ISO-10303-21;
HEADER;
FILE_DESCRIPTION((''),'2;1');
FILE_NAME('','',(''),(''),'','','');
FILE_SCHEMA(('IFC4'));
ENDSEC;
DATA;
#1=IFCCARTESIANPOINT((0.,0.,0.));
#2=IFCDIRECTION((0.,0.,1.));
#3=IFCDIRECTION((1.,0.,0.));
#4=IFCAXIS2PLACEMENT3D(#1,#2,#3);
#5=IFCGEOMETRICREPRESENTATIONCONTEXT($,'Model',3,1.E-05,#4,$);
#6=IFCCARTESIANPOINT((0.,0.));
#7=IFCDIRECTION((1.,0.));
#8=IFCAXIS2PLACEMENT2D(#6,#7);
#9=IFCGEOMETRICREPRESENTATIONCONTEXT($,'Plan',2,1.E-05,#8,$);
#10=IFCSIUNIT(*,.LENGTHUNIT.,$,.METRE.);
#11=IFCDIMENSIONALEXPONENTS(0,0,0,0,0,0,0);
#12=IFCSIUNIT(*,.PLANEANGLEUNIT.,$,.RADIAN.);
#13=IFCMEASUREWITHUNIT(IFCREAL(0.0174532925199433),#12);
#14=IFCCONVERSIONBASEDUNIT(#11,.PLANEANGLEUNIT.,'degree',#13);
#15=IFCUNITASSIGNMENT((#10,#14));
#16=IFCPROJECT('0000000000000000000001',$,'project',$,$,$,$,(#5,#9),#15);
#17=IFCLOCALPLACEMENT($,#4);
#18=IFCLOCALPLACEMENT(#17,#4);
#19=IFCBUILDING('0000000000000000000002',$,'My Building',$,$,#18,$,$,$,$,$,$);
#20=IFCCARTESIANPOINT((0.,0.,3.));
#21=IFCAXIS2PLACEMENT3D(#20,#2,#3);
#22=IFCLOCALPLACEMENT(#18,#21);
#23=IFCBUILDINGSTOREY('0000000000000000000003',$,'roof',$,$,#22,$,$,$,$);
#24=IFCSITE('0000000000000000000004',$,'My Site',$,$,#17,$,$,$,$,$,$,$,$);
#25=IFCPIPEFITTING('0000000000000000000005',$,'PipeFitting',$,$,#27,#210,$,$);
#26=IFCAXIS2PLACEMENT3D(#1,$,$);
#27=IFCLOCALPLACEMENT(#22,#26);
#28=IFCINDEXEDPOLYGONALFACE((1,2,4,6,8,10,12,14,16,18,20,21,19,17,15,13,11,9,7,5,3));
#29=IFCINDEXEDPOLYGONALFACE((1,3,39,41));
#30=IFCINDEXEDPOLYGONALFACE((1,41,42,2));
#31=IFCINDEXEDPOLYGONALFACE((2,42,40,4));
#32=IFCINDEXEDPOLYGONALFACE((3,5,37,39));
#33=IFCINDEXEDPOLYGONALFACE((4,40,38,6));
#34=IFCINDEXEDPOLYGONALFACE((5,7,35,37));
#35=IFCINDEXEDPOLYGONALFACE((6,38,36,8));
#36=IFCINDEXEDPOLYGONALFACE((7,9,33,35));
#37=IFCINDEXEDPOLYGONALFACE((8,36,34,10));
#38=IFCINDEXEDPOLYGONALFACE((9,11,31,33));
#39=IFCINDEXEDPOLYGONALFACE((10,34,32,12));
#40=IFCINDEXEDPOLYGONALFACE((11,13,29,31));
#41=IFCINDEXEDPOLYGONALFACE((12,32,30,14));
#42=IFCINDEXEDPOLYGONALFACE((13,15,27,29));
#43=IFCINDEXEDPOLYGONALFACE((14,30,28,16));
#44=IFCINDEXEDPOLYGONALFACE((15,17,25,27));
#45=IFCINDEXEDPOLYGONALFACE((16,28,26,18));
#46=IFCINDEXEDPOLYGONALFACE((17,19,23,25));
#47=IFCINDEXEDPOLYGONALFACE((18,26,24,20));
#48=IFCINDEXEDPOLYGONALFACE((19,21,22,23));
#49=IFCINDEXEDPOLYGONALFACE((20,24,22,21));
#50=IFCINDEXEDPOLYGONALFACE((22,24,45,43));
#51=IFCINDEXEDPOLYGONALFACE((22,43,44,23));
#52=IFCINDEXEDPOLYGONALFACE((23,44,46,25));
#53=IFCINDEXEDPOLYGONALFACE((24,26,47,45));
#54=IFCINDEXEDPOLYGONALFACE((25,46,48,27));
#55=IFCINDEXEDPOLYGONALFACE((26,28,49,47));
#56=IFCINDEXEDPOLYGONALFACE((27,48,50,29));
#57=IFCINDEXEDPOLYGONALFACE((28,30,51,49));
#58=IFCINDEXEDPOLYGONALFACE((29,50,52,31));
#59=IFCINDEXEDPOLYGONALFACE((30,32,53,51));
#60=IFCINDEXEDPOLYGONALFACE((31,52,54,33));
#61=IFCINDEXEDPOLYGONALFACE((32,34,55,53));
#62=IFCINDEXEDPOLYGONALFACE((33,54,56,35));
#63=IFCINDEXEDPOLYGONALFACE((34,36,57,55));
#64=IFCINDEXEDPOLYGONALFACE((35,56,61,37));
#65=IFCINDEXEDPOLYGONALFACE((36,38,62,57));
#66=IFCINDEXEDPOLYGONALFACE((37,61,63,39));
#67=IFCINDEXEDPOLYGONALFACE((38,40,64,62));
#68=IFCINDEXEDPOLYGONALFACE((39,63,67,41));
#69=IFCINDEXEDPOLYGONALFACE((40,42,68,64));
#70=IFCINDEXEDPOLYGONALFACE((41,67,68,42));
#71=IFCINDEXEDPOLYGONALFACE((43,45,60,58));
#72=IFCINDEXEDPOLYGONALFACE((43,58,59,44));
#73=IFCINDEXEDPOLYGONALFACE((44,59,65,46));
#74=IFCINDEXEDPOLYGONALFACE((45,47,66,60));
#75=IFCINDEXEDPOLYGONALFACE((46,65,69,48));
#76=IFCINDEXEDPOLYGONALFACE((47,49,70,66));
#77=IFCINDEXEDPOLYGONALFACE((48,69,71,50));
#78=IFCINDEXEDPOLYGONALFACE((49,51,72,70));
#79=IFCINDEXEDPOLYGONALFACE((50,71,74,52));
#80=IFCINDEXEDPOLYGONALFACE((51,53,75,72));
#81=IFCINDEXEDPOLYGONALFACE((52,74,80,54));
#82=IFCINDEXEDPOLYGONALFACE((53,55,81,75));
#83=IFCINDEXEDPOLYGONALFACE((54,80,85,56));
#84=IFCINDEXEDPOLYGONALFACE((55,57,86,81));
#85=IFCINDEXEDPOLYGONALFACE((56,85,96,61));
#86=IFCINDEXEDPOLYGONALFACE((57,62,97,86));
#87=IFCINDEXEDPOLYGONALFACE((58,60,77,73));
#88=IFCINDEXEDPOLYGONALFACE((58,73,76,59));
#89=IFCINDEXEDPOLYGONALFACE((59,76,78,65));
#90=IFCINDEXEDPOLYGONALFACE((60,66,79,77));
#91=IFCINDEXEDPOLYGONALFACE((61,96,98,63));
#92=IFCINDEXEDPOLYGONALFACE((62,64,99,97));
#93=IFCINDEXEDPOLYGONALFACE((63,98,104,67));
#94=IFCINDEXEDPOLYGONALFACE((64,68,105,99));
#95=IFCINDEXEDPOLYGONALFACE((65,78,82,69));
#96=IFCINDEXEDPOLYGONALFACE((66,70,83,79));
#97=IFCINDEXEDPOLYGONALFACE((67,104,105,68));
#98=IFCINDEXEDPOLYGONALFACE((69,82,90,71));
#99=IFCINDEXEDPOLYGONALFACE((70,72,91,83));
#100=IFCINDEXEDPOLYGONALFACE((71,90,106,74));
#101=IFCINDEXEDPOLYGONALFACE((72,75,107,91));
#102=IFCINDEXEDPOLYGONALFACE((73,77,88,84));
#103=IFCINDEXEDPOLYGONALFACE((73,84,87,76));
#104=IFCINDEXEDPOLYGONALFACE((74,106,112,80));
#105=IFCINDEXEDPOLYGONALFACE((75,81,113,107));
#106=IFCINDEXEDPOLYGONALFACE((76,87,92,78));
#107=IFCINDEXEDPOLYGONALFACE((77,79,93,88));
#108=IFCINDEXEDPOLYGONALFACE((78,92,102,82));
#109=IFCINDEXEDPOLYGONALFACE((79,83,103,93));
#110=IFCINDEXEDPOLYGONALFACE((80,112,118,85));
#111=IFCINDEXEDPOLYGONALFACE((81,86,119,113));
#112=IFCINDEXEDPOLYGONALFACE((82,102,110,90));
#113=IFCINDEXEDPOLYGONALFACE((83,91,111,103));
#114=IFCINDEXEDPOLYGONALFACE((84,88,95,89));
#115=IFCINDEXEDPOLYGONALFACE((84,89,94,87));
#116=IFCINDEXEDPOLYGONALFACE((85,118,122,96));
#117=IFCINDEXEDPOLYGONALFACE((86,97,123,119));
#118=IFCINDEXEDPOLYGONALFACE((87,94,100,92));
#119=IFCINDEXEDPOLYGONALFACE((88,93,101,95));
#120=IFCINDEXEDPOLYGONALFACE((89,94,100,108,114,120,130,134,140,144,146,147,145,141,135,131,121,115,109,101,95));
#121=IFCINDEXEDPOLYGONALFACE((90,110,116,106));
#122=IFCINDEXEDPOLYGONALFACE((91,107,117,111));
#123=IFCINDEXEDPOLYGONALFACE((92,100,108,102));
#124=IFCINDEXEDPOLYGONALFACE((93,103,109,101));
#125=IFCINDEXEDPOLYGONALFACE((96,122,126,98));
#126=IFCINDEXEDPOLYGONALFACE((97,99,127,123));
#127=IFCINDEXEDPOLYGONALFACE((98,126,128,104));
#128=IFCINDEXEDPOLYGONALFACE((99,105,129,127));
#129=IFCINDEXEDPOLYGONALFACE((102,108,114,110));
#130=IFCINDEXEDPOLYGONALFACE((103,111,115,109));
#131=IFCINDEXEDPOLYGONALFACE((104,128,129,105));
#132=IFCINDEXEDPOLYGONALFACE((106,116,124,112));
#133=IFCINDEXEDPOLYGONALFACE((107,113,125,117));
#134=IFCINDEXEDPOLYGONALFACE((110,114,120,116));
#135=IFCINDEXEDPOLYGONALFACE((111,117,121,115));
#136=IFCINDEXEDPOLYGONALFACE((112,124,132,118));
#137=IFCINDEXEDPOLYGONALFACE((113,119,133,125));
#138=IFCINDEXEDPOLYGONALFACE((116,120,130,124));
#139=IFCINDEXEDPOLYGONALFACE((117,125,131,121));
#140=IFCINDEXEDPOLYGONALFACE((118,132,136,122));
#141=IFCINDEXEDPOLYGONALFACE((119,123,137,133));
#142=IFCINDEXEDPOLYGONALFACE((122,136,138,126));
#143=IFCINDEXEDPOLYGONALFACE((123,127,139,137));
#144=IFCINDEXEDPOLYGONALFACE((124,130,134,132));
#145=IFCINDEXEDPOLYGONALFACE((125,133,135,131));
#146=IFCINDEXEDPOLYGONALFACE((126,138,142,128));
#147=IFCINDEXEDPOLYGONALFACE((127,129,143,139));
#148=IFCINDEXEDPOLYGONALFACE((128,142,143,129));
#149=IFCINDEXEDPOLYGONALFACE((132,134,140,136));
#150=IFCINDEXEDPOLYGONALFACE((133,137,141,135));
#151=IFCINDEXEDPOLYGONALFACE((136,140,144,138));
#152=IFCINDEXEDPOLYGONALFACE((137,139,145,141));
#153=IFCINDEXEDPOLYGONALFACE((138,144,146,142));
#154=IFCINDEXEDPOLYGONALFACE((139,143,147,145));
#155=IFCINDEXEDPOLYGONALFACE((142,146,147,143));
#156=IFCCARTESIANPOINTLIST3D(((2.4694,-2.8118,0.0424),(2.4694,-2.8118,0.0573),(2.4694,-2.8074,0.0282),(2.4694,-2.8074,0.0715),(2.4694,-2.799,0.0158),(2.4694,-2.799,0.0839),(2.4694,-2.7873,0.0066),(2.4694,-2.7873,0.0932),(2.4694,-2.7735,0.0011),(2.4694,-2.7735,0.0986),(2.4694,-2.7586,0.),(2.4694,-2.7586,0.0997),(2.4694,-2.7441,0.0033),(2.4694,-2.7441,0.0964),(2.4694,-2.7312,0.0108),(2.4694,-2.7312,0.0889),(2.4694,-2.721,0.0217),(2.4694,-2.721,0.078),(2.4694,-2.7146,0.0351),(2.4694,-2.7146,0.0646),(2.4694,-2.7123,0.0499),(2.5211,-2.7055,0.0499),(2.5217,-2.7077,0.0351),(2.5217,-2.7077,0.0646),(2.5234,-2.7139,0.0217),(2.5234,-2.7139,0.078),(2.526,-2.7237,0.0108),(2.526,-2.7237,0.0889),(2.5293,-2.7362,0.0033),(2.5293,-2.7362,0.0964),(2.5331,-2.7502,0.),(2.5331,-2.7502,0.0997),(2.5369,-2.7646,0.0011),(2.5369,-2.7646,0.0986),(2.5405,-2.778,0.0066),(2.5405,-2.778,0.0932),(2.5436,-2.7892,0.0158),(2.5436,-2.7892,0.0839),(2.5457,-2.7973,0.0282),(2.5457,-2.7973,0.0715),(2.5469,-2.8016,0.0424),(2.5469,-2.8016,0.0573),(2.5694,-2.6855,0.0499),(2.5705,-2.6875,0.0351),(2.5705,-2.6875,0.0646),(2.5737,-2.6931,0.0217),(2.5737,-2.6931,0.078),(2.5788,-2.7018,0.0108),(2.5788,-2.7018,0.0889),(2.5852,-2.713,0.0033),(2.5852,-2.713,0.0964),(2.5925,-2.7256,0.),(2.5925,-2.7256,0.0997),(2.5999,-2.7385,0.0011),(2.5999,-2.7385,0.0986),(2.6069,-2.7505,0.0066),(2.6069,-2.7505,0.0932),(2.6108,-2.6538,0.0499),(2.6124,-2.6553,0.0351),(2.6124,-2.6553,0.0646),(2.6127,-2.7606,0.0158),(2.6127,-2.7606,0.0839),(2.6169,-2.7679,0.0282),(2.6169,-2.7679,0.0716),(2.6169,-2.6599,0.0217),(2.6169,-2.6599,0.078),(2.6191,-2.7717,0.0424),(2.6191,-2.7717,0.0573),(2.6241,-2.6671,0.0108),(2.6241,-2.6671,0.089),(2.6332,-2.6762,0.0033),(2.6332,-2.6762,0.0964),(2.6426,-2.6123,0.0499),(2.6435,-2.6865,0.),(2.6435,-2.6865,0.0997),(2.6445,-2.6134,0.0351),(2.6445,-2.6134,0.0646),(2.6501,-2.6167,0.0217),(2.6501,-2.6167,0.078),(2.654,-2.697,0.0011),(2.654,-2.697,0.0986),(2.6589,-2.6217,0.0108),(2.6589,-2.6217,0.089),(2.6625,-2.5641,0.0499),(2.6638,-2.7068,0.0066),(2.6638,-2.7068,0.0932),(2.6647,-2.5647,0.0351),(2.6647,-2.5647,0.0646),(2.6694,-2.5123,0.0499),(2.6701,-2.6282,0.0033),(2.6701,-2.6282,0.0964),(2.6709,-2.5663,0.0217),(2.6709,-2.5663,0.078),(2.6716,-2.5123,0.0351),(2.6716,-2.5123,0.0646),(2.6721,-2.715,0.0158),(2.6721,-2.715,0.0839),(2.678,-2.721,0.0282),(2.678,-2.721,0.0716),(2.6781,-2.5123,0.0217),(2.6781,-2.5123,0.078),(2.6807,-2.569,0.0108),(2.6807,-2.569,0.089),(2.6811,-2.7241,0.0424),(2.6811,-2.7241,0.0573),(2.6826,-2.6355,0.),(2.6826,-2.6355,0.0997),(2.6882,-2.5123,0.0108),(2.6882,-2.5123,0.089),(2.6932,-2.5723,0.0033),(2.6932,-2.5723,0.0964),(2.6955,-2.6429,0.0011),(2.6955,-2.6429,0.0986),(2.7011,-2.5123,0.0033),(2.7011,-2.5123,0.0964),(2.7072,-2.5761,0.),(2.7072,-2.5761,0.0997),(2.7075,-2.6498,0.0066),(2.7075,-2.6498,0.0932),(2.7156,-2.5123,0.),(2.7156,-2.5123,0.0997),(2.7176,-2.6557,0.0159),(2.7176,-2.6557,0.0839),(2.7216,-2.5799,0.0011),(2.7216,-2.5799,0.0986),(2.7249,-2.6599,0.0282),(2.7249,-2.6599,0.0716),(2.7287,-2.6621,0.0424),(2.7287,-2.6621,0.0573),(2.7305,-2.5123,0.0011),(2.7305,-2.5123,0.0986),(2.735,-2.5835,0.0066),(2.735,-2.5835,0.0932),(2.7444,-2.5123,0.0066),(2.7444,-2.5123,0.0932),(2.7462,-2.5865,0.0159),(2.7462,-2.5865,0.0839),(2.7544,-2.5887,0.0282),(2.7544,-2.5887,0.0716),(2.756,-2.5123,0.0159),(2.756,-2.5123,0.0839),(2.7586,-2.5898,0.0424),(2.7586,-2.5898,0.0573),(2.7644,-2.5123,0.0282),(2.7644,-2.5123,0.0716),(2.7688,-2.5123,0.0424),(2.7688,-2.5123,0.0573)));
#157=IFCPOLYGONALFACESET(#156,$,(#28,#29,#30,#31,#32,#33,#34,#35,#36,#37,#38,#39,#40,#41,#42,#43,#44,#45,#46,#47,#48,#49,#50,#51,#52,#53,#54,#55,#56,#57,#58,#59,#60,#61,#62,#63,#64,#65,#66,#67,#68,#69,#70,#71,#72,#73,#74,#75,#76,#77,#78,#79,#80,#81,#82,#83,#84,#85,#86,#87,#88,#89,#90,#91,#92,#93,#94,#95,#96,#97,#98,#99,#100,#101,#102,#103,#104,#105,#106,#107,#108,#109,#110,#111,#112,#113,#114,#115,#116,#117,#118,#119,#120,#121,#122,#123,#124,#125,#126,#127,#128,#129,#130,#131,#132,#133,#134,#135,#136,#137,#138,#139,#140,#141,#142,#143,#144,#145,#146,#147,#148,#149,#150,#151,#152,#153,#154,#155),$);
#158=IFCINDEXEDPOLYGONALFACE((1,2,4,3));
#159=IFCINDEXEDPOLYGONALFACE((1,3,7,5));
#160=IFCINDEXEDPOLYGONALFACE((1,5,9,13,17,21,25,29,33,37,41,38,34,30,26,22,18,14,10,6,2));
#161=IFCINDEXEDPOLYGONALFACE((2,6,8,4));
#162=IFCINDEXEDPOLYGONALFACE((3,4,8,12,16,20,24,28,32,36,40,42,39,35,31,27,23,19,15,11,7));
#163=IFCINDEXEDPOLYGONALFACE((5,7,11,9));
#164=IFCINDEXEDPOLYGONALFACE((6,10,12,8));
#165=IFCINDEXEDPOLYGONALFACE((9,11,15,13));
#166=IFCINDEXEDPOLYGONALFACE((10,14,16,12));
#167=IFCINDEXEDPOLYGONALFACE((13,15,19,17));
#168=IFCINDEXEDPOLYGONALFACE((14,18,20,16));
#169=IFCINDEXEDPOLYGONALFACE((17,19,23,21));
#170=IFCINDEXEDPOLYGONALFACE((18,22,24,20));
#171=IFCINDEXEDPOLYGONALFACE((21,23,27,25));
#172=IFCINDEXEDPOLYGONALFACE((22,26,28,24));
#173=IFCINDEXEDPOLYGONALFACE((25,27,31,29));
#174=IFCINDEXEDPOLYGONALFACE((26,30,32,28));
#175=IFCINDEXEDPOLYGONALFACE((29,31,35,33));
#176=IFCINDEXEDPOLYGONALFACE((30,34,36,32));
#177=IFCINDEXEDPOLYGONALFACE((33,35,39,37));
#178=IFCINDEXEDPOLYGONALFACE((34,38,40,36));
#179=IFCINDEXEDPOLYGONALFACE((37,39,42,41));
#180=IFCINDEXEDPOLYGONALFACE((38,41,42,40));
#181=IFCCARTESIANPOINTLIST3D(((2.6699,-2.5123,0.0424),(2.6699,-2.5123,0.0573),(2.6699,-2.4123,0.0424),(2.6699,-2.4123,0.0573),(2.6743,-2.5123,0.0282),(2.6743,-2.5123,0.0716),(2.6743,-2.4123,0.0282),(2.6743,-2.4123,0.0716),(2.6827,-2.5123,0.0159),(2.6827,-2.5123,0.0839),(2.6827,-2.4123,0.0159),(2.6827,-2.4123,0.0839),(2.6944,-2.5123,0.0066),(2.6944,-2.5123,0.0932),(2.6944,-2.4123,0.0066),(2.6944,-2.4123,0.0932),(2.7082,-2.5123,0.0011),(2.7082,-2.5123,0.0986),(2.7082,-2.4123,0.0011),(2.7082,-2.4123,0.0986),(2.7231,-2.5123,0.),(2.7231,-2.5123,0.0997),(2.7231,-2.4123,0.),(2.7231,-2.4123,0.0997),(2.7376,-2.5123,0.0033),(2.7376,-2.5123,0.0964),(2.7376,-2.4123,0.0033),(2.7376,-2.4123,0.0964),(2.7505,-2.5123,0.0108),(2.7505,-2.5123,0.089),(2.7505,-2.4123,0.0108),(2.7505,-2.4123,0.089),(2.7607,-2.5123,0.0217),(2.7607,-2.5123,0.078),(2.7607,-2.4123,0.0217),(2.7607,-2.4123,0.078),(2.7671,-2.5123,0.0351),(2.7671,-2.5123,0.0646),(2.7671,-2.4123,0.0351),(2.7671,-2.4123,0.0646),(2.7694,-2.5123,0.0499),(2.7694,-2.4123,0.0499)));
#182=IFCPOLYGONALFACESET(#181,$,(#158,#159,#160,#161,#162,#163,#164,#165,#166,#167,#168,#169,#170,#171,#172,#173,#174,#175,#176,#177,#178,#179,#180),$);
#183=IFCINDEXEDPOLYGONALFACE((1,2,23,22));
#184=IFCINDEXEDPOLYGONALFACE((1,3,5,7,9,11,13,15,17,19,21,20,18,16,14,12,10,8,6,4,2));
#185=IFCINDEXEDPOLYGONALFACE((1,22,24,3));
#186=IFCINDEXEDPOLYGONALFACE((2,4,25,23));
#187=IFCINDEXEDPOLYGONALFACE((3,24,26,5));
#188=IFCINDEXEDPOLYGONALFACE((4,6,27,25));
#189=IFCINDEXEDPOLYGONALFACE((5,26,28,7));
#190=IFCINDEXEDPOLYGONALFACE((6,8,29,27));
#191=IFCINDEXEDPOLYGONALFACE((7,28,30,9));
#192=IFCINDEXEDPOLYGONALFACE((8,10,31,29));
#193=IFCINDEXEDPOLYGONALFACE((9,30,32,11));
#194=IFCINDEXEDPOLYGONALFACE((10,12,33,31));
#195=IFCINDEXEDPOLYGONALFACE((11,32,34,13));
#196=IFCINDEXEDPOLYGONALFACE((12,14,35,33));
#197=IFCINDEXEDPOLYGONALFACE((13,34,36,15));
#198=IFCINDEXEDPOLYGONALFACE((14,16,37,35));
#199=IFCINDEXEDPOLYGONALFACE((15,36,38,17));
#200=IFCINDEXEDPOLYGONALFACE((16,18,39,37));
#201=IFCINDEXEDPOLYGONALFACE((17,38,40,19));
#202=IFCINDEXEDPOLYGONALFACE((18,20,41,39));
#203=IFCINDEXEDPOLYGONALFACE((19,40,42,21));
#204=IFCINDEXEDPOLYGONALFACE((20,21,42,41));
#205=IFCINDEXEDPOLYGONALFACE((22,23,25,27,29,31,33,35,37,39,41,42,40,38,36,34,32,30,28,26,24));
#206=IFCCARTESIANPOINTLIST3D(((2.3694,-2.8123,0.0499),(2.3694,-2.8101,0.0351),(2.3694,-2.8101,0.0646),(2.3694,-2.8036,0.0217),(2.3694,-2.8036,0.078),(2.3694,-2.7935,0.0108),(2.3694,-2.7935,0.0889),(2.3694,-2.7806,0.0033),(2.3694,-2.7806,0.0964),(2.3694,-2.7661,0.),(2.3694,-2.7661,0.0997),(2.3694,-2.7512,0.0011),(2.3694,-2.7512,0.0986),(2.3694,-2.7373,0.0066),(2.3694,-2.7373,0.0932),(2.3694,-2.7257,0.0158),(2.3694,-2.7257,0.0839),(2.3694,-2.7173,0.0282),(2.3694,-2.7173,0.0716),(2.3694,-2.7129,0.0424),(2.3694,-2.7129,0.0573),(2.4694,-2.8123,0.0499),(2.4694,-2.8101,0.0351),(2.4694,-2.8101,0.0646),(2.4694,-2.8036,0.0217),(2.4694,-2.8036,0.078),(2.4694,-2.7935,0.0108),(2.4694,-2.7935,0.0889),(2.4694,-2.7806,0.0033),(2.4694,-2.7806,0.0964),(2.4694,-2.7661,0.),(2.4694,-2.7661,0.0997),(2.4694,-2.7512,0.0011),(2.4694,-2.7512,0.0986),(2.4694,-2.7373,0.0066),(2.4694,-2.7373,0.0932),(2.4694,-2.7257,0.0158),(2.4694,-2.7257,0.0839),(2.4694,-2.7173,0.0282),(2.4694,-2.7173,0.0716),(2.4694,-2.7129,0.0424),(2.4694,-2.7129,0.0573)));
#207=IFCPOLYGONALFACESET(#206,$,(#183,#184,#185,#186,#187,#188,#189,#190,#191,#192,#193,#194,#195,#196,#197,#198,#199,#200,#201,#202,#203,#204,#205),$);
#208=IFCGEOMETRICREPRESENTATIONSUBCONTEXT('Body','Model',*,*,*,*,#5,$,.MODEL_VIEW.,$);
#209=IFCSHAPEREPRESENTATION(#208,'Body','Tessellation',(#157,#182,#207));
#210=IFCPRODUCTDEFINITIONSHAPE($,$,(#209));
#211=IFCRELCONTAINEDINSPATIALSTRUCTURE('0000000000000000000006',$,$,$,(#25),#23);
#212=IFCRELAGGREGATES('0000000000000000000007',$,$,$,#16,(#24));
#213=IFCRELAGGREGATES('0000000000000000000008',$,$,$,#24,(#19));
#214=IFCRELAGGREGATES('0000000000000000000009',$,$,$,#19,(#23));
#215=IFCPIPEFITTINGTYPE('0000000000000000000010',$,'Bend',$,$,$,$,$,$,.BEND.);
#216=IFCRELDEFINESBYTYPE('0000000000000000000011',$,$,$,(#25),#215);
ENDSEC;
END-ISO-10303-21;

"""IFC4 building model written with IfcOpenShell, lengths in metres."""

from ifc_helpers import new_model, entity, si_unit, converted_unit, frame, origin_with_axes, origin_2d_with_axis, place, context, subcontext, project, spatial, circle, extrude, source, transform, mapped, type_object, type_shapes, element, save


model = new_model("IFC4")

# Units and contexts
model_context = context("Model", 3, precision=1e-05, world=origin_with_axes())
plan_context = context("Plan", 2, precision=1e-05, world=origin_2d_with_axis())
body_context = subcontext(model_context, "Body", "Model", "MODEL_VIEW")
ifc_project = project(units=[si_unit("LENGTHUNIT", "METRE"), converted_unit("PLANEANGLEUNIT", "degree", entity("IfcReal", 0.0174532925199433), si_unit("PLANEANGLEUNIT", "RADIAN"), dimensions=[0, 0, 0, 0, 0, 0, 0])], contexts=[model_context, plan_context])

# Site, building, storey
site_placement = place(None, origin_with_axes())
site = spatial("IfcSite", under=ifc_project, at=site_placement, Name="My Site")
building_placement = place(site_placement, origin_with_axes())
building = spatial("IfcBuilding", under=site, at=building_placement, Name="My Building")
storey_placement = place(building_placement, frame((0.0, 0.0, 3.0), z_axis=(0.0, 0.0, 1.0), x_axis=(1.0, 0.0, 0.0)))
storey = spatial("IfcBuildingStorey", under=building, at=storey_placement, Name="roof")

# Pipe fitting
pipe_fitting_type_1 = type_object("IfcPipeFittingType", Name="Bend", PredefinedType="BEND")
shared_shape_1 = source(origin_with_axes(), body_context, "Body", "SolidModel", [
    entity("IfcSweptDiskSolid", entity("IfcIndexedPolyCurve", entity("IfcCartesianPointList3D", [[0.0, 0.0, -0.1], [-0.0732, 0.0, -0.2768], [-0.25, 0.0, -0.35]]), [entity("IfcArcIndex", [1, 2, 3])]), 0.05),
    extrude(circle(Radius=0.05), origin_with_axes(), (0.0, 0.0, -1.0), 0.1),
    extrude(circle(Radius=0.05), frame((-0.25, 0.0, -0.35), z_axis=(-1.0, 0.0, 0.0), x_axis=(0.0, 0.0, -1.0)), (0.0, 0.0, 1.0), 0.1),
])
type_shapes(pipe_fitting_type_1, [shared_shape_1])
for number, where, z_axis, x_axis, name in (
    (1, (2.7194, -2.4123, 0.0499), (0.0, 1.0, 0.000029), (1.0, 0.0, 0.0), "PipeFitting"),
):
    element("IfcPipeFitting", number, at=place(storey_placement, frame(where, z_axis=z_axis, x_axis=x_axis)), inside=storey, type_object=pipe_fitting_type_1, Name=name, context=body_context, shape_type="MappedRepresentation", body=[
        mapped(shared_shape_1, transform((0.0, 0.0, 0.0), x_axis=(1.0, 0.0, 0.0), y_axis=(0.0, 1.0, 0.0), z_axis=(0.0, 0.0, 1.0), scale=1.0)),
    ])

save(model, "model.ifc")
